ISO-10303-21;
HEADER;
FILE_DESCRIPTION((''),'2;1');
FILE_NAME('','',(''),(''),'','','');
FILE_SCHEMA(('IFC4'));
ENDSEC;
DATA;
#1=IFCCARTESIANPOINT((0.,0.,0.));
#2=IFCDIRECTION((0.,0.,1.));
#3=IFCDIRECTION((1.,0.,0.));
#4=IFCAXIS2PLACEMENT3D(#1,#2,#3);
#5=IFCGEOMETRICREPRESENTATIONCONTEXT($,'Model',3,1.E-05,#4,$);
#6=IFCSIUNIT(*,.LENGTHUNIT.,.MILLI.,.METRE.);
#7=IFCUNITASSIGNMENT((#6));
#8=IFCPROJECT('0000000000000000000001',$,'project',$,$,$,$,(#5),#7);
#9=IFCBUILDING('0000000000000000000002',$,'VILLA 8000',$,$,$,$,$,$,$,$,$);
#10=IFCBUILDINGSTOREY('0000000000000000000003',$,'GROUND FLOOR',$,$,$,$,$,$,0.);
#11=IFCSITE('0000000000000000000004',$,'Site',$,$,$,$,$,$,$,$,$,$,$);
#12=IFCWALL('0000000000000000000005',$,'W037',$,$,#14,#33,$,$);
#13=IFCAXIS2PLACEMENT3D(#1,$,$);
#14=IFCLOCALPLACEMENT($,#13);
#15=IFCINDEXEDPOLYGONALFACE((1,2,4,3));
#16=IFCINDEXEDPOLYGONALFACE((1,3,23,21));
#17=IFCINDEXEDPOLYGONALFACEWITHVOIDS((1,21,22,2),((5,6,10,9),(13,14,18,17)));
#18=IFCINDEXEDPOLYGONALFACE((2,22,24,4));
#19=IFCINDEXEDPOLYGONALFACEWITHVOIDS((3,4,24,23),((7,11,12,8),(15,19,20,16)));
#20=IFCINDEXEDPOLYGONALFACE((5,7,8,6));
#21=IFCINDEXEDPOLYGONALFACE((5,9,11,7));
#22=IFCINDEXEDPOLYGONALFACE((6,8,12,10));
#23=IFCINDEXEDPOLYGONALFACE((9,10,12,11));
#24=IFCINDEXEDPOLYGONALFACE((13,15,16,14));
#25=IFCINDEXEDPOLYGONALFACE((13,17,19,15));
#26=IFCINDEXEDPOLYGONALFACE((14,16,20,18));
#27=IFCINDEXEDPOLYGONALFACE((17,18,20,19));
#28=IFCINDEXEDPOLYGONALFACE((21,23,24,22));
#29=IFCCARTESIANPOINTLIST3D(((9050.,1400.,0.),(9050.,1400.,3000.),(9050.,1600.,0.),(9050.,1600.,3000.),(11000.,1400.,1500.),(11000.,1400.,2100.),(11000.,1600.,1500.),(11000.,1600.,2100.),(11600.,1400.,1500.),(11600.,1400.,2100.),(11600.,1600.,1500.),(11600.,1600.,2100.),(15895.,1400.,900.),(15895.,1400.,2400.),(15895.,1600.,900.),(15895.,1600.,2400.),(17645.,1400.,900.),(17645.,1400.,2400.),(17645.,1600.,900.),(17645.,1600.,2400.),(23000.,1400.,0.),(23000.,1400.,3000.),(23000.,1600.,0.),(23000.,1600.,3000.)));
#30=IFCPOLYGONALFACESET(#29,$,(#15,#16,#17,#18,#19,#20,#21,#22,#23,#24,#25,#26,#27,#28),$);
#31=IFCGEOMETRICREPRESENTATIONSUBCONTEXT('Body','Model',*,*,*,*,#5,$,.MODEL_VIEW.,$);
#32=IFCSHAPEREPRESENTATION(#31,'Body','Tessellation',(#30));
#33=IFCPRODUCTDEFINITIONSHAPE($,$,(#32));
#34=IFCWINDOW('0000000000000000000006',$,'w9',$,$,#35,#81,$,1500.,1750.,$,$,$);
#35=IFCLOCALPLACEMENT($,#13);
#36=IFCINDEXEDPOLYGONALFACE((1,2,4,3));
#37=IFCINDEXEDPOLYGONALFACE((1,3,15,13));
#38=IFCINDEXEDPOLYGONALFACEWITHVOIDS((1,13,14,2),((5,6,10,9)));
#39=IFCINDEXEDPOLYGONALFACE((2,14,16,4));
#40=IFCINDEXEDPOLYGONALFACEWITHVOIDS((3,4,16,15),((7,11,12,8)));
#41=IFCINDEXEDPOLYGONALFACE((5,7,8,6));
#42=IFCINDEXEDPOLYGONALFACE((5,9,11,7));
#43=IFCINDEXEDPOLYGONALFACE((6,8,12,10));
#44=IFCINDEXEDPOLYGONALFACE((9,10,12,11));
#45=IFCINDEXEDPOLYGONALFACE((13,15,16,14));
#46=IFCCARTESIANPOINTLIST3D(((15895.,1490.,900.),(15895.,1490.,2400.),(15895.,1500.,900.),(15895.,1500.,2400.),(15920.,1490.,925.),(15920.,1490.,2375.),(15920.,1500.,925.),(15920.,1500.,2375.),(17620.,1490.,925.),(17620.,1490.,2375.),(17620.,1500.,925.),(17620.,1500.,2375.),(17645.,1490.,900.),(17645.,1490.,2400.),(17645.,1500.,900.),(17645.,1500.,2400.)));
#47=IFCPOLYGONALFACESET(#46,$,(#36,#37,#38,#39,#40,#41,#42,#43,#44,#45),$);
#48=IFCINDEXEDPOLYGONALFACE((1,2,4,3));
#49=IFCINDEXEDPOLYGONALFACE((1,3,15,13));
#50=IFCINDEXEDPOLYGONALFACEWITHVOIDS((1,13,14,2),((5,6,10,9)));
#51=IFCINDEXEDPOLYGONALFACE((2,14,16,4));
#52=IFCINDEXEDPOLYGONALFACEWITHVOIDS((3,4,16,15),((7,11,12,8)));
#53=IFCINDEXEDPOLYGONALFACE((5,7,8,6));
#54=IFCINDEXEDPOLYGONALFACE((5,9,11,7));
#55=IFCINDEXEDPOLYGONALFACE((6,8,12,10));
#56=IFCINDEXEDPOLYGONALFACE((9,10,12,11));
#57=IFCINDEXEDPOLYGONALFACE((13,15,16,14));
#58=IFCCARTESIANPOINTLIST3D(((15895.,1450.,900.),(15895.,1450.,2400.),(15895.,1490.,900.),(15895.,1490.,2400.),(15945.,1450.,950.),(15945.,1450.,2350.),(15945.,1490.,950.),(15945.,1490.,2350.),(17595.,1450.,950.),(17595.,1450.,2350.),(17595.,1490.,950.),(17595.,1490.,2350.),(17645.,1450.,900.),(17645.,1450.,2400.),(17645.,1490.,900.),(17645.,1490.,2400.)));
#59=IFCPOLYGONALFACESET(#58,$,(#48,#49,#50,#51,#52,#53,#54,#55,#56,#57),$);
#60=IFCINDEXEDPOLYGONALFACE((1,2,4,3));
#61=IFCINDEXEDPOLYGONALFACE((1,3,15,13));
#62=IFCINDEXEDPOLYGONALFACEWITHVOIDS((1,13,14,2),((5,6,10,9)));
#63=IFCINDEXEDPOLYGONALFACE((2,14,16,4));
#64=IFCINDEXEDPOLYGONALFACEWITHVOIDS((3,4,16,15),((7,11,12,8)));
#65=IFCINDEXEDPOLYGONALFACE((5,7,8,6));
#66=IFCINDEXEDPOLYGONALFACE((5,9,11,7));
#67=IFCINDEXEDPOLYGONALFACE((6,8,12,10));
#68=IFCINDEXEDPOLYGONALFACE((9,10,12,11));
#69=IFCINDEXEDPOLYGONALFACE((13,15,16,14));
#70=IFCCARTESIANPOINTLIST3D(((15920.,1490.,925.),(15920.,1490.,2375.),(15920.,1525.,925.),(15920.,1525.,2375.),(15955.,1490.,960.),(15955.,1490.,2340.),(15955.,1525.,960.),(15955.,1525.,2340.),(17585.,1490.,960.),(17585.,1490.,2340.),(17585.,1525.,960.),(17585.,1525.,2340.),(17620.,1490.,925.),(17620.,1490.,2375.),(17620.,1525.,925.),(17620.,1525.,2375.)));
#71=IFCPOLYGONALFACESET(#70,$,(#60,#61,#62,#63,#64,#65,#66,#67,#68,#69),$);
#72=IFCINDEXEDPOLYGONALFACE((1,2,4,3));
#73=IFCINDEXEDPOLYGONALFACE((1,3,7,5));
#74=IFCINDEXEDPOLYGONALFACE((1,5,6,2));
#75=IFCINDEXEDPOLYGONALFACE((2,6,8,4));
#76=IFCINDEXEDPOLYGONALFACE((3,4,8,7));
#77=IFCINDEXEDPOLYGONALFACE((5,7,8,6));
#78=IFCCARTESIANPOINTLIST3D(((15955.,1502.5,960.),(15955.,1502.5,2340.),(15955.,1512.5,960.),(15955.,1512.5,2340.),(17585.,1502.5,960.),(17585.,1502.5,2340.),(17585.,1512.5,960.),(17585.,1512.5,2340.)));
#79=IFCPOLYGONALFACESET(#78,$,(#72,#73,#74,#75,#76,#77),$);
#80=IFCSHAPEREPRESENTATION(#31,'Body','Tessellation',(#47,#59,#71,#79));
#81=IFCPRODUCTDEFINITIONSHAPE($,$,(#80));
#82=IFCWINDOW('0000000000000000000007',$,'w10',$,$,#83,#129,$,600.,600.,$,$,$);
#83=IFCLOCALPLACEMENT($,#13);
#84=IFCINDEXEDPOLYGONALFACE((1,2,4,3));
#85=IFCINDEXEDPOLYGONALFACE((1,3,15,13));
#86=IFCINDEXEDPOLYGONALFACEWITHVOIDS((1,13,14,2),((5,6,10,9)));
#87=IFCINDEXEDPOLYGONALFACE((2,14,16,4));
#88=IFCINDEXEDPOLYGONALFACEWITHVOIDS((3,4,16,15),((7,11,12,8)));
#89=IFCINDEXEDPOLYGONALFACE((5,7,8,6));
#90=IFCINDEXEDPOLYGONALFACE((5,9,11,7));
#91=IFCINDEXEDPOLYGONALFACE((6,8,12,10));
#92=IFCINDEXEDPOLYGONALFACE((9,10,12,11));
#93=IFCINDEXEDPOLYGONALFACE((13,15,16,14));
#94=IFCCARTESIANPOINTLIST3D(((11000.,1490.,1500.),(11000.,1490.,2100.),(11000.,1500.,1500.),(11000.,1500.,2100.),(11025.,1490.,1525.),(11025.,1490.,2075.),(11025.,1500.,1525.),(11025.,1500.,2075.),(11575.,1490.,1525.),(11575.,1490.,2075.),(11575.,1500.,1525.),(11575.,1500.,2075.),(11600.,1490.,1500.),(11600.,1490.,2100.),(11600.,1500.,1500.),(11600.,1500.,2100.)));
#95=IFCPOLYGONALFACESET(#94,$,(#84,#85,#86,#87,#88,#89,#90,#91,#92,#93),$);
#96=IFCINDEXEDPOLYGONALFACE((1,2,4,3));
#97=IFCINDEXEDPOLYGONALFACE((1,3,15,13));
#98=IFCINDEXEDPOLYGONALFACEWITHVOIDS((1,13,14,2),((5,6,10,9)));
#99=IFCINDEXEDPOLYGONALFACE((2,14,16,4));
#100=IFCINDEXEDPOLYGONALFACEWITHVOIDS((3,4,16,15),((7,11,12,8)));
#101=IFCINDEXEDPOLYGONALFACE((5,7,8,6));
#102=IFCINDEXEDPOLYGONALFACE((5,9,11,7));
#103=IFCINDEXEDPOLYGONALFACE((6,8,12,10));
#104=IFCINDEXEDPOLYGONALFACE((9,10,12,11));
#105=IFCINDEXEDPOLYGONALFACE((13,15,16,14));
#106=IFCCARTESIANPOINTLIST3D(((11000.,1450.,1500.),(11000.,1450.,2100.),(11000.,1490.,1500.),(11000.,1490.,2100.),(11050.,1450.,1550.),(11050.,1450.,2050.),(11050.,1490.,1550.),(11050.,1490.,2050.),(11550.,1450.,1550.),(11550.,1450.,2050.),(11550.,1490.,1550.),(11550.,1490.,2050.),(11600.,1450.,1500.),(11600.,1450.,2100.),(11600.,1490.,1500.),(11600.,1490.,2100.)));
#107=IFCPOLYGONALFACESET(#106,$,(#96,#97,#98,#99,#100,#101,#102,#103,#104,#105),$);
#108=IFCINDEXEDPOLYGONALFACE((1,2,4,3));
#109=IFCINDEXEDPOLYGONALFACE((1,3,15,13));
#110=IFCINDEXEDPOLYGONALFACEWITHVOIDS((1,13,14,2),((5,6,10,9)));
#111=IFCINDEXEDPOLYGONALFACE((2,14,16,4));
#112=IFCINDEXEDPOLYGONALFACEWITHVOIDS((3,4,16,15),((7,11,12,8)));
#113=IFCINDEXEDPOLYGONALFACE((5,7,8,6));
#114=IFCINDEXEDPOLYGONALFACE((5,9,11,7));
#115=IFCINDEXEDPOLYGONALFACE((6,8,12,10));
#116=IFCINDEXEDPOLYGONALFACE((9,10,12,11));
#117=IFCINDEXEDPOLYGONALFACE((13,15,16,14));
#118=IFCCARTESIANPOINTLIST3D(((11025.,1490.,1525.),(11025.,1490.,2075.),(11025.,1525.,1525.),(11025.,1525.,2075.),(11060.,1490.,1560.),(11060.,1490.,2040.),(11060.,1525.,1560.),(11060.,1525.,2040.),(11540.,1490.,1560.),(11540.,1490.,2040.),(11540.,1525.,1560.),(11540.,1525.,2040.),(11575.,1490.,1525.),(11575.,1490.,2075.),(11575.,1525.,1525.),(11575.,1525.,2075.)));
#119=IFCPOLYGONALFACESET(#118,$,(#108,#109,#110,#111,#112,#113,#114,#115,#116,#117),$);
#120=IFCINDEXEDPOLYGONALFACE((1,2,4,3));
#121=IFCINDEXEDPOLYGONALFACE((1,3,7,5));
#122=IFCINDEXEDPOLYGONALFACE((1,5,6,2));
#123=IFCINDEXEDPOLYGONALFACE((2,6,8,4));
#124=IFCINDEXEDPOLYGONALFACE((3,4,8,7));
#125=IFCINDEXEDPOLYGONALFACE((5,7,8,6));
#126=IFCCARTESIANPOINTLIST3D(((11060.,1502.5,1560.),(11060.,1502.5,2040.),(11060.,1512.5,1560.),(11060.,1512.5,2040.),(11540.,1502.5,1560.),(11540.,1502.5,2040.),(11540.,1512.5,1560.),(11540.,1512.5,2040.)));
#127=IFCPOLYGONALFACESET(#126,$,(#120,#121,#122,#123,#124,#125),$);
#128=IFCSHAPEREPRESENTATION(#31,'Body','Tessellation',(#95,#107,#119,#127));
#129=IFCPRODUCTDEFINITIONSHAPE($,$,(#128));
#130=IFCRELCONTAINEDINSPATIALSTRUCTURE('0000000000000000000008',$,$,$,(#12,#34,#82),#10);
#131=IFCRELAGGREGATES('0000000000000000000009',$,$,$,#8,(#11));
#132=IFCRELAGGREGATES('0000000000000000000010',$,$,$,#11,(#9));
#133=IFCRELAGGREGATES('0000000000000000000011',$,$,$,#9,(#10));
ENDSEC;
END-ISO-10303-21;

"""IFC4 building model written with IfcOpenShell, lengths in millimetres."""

from ifc_helpers import new_model, si_unit, frame, origin_with_axes, place, context, subcontext, project, spatial, line, indexed_curve, outline, extrude, element, fill, save


model = new_model("IFC4")

# Units and contexts
model_context = context("Model", 3, precision=1e-05, world=origin_with_axes())
body_context = subcontext(model_context, "Body", "Model", "MODEL_VIEW")
ifc_project = project(units=[si_unit("LENGTHUNIT", "METRE", prefix="MILLI")], contexts=[model_context])

# Site, building, storey
site = spatial("IfcSite", under=ifc_project, Name="Site")
building = spatial("IfcBuilding", under=site, Name="VILLA 8000")
storey = spatial("IfcBuildingStorey", under=building, Name="GROUND FLOOR", Elevation=0.0)

# Wall, openings, windows
wall_1_placement = place(None, frame((9050.0, 1500.0, 0.0), z_axis=(0.0, 0.0, 1.0), x_axis=(1.0, 0.0, 0.0)))
wall_1 = element("IfcWall", 1, at=wall_1_placement, inside=storey, Name="W037", context=body_context, shape_type="SweptSolid", body=[
    extrude(outline(indexed_curve([(0.0, 0.0), (0.0, 200.0), (13950.0, 200.0), (13950.0, 0.0), (0.0, 0.0)], self_intersect=False)), frame((0.0, -100.0, 0.0), z_axis=(0.0, 0.0, 1.0), x_axis=(1.0, 0.0, 0.0)), (0.0, 0.0, 1.0), 3000.0),
])
opening_1_placement = place(wall_1_placement, frame((6845.0, 0.0, 900.0), z_axis=(0.0, 0.0, 1.0), x_axis=(1.0, 0.0, 0.0)))
opening_1 = element("IfcOpeningElement", 2, at=opening_1_placement, cuts=wall_1, context=body_context, shape_type="SweptSolid", body=[
    extrude(outline(indexed_curve([(0.0, 0.0), (0.0, 300.0), (1750.0, 300.0), (1750.0, 0.0), (0.0, 0.0)], self_intersect=False)), frame((0.0, -150.0, 0.0), z_axis=(0.0, 0.0, 1.0), x_axis=(1.0, 0.0, 0.0)), (0.0, 0.0, 1.0), 1500.0),
])
opening_2_placement = place(wall_1_placement, frame((1950.0, 0.0, 1500.0), z_axis=(0.0, 0.0, 1.0), x_axis=(1.0, 0.0, 0.0)))
opening_2 = element("IfcOpeningElement", 3, at=opening_2_placement, cuts=wall_1, context=body_context, shape_type="SweptSolid", body=[
    extrude(outline(indexed_curve([(0.0, 0.0), (0.0, 300.0), (600.0, 300.0), (600.0, 0.0), (0.0, 0.0)], self_intersect=False)), frame((0.0, -150.0, 0.0), z_axis=(0.0, 0.0, 1.0), x_axis=(1.0, 0.0, 0.0)), (0.0, 0.0, 1.0), 600.0),
])
window_1_placement = place(None, frame((15895.0, 1400.0, 900.0), z_axis=(0.0, 0.0, 1.0), x_axis=(1.0, 0.0, 0.0)))
window_1 = element("IfcWindow", 4, at=window_1_placement, inside=storey, Name="w9", OverallHeight=1500.0, OverallWidth=1750.0, context=body_context, shape_type="SweptSolid", body=[
    extrude(outline(indexed_curve([(0.0, 0.0), (1750.0, 0.0), (1750.0, 1500.0), (0.0, 1500.0)], segments=[line(1, 2, 3, 4, 1)]), holes=[indexed_curve([(25.0, 25.0), (1725.0, 25.0), (1725.0, 1475.0), (25.0, 1475.0)], segments=[line(1, 2, 3, 4, 1)])]), frame((0.0, 90.0, 0.0), z_axis=(0.0, -1.0, 0.0), x_axis=(1.0, 0.0, 0.0)), (0.0, 0.0, -1.0), 10.0),
    extrude(outline(indexed_curve([(0.0, 0.0), (1750.0, 0.0), (1750.0, 1500.0), (0.0, 1500.0)], segments=[line(1, 2, 3, 4, 1)]), holes=[indexed_curve([(50.0, 50.0), (1700.0, 50.0), (1700.0, 1450.0), (50.0, 1450.0)], segments=[line(1, 2, 3, 4, 1)])]), frame((0.0, 50.0, 0.0), z_axis=(0.0, -1.0, 0.0), x_axis=(1.0, 0.0, 0.0)), (0.0, 0.0, -1.0), 40.0),
    extrude(outline(indexed_curve([(0.0, 0.0), (1700.0, 0.0), (1700.0, 1450.0), (0.0, 1450.0)], segments=[line(1, 2, 3, 4, 1)]), holes=[indexed_curve([(35.0, 35.0), (1665.0, 35.0), (1665.0, 1415.0), (35.0, 1415.0)], segments=[line(1, 2, 3, 4, 1)])]), frame((25.0, 90.0, 25.0), z_axis=(0.0, -1.0, 0.0), x_axis=(1.0, 0.0, 0.0)), (0.0, 0.0, -1.0), 35.0),
    extrude(outline(indexed_curve([(35.0, 35.0), (1665.0, 35.0), (1665.0, 1415.0), (35.0, 1415.0)], segments=[line(1, 2, 3, 4, 1)])), frame((25.0, 102.5, 25.0), z_axis=(0.0, -1.0, 0.0), x_axis=(1.0, 0.0, 0.0)), (0.0, 0.0, -1.0), 10.0),
])
fill(opening_1, window_1)
window_2_placement = place(None, frame((11000.0, 1400.0, 1500.0), z_axis=(0.0, 0.0, 1.0), x_axis=(1.0, 0.0, 0.0)))
window_2 = element("IfcWindow", 5, at=window_2_placement, inside=storey, Name="w10", OverallHeight=600.0, OverallWidth=600.0, context=body_context, shape_type="SweptSolid", body=[
    extrude(outline(indexed_curve([(0.0, 0.0), (600.0, 0.0), (600.0, 600.0), (0.0, 600.0)], segments=[line(1, 2, 3, 4, 1)]), holes=[indexed_curve([(25.0, 25.0), (575.0, 25.0), (575.0, 575.0), (25.0, 575.0)], segments=[line(1, 2, 3, 4, 1)])]), frame((0.0, 90.0, 0.0), z_axis=(0.0, -1.0, 0.0), x_axis=(1.0, 0.0, 0.0)), (0.0, 0.0, -1.0), 10.0),
    extrude(outline(indexed_curve([(0.0, 0.0), (600.0, 0.0), (600.0, 600.0), (0.0, 600.0)], segments=[line(1, 2, 3, 4, 1)]), holes=[indexed_curve([(50.0, 50.0), (550.0, 50.0), (550.0, 550.0), (50.0, 550.0)], segments=[line(1, 2, 3, 4, 1)])]), frame((0.0, 50.0, 0.0), z_axis=(0.0, -1.0, 0.0), x_axis=(1.0, 0.0, 0.0)), (0.0, 0.0, -1.0), 40.0),
    extrude(outline(indexed_curve([(0.0, 0.0), (550.0, 0.0), (550.0, 550.0), (0.0, 550.0)], segments=[line(1, 2, 3, 4, 1)]), holes=[indexed_curve([(35.0, 35.0), (515.0, 35.0), (515.0, 515.0), (35.0, 515.0)], segments=[line(1, 2, 3, 4, 1)])]), frame((25.0, 90.0, 25.0), z_axis=(0.0, -1.0, 0.0), x_axis=(1.0, 0.0, 0.0)), (0.0, 0.0, -1.0), 35.0),
    extrude(outline(indexed_curve([(35.0, 35.0), (515.0, 35.0), (515.0, 515.0), (35.0, 515.0)], segments=[line(1, 2, 3, 4, 1)])), frame((25.0, 102.5, 25.0), z_axis=(0.0, -1.0, 0.0), x_axis=(1.0, 0.0, 0.0)), (0.0, 0.0, -1.0), 10.0),
])
fill(opening_2, window_2)

save(model, "model.ifc")
